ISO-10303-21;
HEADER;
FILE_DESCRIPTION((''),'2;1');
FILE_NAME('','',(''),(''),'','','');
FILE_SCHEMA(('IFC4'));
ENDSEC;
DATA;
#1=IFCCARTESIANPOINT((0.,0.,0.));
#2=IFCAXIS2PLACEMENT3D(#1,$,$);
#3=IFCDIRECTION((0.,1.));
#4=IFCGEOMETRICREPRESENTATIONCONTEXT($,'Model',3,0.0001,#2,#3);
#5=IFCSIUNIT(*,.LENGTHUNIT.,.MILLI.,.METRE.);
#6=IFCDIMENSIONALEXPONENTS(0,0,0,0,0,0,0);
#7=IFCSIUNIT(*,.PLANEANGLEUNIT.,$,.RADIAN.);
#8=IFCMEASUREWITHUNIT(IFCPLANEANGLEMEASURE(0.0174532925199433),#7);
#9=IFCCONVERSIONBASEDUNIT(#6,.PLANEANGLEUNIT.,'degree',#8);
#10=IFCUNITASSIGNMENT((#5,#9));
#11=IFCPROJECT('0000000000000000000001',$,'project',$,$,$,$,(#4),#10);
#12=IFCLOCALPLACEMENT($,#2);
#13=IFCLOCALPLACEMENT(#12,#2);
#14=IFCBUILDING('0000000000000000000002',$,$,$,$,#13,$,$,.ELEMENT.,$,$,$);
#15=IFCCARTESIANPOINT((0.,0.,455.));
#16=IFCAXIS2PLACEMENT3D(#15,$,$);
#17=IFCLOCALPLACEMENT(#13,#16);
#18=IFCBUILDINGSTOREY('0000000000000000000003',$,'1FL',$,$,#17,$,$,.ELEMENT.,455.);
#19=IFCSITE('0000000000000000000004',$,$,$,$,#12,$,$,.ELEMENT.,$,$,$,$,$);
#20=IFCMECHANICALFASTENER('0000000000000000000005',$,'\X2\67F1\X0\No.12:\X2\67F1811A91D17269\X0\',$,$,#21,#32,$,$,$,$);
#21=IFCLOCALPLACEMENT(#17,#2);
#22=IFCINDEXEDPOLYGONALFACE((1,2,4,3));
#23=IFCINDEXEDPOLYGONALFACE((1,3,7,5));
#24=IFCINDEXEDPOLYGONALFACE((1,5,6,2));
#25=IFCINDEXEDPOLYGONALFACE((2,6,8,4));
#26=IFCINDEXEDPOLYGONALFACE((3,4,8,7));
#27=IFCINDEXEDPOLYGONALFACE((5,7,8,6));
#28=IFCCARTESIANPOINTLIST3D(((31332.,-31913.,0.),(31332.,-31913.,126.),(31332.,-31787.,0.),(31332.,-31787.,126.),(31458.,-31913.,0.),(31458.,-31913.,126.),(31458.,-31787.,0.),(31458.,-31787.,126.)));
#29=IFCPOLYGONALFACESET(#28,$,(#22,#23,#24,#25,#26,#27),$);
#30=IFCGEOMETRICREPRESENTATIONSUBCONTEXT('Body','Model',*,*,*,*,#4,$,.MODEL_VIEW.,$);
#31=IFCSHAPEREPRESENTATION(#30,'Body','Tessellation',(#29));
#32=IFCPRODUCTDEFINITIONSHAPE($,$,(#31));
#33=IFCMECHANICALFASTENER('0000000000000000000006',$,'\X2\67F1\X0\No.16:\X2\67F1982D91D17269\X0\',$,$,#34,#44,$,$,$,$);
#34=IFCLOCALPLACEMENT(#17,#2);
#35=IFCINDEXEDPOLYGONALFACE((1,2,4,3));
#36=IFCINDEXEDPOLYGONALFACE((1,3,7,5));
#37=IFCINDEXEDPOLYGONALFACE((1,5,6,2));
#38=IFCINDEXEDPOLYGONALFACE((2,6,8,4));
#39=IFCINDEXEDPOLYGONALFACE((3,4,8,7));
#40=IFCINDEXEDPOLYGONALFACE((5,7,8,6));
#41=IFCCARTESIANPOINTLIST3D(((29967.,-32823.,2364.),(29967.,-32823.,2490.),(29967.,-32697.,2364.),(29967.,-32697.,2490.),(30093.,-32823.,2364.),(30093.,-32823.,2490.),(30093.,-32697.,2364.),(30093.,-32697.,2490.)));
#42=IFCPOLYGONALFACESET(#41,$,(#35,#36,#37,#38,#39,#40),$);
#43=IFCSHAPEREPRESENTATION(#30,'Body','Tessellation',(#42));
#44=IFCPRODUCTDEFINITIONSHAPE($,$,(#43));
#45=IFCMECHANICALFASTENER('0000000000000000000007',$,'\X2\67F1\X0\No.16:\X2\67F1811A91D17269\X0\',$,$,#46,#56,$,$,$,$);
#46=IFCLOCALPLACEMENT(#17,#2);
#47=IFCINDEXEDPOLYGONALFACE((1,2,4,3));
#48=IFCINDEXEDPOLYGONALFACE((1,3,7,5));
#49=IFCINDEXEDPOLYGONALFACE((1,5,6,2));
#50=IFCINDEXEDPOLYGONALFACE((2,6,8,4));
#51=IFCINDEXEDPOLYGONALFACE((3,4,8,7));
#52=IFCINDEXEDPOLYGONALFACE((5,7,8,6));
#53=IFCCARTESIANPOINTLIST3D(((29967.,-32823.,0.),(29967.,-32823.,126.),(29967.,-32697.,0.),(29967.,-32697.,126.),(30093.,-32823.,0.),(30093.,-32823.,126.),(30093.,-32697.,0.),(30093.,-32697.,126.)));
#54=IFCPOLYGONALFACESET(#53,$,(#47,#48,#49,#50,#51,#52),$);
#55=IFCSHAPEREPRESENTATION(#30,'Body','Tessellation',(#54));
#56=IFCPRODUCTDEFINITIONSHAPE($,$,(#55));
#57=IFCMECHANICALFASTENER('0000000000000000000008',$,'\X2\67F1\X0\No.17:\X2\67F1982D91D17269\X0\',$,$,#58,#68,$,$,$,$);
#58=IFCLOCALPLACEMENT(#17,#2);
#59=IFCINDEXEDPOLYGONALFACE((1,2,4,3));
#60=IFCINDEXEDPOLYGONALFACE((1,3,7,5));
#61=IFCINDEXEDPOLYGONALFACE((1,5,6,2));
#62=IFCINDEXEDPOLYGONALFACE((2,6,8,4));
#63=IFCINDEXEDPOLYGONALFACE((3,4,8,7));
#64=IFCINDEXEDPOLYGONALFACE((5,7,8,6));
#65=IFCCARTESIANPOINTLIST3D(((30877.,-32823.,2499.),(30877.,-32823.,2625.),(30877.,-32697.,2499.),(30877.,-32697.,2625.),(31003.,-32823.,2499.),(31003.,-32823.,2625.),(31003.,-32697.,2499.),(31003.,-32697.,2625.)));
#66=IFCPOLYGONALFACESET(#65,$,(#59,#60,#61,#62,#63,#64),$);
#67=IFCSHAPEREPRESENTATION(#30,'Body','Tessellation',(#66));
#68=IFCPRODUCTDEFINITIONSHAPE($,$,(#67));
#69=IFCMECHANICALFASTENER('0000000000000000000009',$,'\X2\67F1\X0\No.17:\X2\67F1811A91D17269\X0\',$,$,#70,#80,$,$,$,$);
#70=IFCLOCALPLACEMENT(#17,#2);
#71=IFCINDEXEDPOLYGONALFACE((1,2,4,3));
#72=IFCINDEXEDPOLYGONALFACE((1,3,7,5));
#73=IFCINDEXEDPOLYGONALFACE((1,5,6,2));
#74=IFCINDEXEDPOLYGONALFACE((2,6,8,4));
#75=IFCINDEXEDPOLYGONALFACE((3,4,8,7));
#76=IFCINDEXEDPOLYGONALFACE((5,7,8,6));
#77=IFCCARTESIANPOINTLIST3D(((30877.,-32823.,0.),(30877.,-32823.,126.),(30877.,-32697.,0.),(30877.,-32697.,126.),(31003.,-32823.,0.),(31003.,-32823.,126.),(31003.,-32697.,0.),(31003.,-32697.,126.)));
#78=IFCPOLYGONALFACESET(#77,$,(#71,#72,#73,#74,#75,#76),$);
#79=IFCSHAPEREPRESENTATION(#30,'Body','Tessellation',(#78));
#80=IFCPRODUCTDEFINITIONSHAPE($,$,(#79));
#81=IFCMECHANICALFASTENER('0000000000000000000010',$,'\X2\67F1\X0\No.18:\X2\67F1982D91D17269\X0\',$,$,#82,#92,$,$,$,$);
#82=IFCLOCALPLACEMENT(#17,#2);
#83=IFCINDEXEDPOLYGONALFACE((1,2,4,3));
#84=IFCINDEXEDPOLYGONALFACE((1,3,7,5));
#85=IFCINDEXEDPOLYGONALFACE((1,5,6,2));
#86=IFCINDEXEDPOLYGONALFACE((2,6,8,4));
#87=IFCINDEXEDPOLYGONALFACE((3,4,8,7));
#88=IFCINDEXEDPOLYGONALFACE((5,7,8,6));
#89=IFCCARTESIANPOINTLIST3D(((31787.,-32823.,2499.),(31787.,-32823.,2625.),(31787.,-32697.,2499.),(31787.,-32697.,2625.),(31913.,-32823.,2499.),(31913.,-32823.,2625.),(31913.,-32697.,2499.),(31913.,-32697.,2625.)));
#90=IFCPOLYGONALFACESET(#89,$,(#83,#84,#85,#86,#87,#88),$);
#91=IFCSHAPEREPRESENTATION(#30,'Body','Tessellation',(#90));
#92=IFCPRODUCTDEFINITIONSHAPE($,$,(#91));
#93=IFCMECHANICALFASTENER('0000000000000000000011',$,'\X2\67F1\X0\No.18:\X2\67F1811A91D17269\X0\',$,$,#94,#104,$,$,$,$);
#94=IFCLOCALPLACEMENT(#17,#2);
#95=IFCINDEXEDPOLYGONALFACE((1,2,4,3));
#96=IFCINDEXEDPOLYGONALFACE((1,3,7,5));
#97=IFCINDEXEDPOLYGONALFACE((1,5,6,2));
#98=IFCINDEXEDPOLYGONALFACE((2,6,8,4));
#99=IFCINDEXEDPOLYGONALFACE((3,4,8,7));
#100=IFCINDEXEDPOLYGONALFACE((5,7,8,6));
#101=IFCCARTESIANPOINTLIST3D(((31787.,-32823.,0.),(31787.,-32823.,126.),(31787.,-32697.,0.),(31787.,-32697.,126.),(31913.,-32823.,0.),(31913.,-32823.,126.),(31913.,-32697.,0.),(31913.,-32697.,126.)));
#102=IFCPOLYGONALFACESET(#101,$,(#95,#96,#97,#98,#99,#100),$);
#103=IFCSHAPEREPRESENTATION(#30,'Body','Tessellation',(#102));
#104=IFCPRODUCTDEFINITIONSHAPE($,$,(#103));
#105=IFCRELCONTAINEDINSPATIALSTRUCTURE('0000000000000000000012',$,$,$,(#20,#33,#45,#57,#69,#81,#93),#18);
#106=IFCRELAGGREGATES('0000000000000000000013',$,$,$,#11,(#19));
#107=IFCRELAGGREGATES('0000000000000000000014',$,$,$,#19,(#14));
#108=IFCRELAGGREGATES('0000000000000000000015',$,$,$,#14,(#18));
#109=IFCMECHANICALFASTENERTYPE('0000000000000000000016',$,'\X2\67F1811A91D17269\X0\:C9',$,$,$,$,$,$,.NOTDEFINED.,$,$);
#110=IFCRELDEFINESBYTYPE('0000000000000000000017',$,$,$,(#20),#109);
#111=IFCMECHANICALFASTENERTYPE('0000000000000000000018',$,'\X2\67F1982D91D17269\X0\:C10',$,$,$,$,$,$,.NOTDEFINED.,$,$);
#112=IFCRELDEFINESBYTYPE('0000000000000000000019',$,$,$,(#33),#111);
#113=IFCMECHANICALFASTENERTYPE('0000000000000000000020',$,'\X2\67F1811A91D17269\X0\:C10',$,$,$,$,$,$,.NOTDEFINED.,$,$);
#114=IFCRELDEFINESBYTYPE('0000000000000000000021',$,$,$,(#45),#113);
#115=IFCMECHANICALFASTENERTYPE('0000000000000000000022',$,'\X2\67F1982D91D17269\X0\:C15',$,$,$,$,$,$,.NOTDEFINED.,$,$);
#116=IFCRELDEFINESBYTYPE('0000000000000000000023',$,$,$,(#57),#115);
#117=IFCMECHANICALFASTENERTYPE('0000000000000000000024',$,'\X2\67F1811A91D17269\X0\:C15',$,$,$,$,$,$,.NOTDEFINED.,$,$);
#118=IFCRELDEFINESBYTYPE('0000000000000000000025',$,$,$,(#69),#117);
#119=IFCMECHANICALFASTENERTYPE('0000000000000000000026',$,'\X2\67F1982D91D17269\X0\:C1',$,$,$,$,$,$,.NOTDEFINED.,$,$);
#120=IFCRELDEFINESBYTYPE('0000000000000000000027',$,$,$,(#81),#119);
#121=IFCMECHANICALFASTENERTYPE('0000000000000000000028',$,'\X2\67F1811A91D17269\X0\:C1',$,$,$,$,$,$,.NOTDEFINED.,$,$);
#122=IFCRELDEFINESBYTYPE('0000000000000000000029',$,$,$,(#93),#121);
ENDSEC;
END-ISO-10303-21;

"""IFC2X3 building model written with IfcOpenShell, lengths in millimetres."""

from ifc_helpers import new_model, entity, si_unit, converted_unit, direction, frame, origin, origin_with_axes, origin_2d, place, context, subcontext, project, spatial, rectangle, extrude, type_object, element, save


model = new_model("IFC2X3")

# Units and contexts
model_context = context("Model", 3, precision=0.0001, world=origin(), true_north=direction((0.0, 1.0)))
body_context = subcontext(model_context, "Body", "Model", "MODEL_VIEW")
ifc_project = project(units=[si_unit("LENGTHUNIT", "METRE", prefix="MILLI"), converted_unit("PLANEANGLEUNIT", "degree", entity("IfcPlaneAngleMeasure", 0.0174532925199433), si_unit("PLANEANGLEUNIT", "RADIAN"), dimensions=[0, 0, 0, 0, 0, 0, 0])], contexts=[model_context])

# Site, building, storey
site_placement = place(None, origin())
site = spatial("IfcSite", under=ifc_project, at=site_placement, CompositionType="ELEMENT")
building_placement = place(site_placement, origin())
building = spatial("IfcBuilding", under=site, at=building_placement, CompositionType="ELEMENT")
storey_placement = place(building_placement, frame((0.0, 0.0, 455.0)))
storey = spatial("IfcBuildingStorey", under=building, at=storey_placement, Name="1FL", CompositionType="ELEMENT", Elevation=455.0)

# Mechanical fasteners
mechanical_fastener_type_1 = type_object("IfcMechanicalFastenerType", Name="柱脚金物:C9")
mechanical_fastener_1_placement = place(storey_placement, frame((31395.0, -31850.0, 0.0)))
element("IfcMechanicalFastener", 1, at=mechanical_fastener_1_placement, inside=storey, type_object=mechanical_fastener_type_1, Name="柱No.12:柱脚金物", context=body_context, shape_type="SweptSolid", body=[
    extrude(rectangle(XDim=126.0, YDim=126.0, at=origin_2d()), origin_with_axes(), (0.0, 0.0, 1.0), 126.0),
])
mechanical_fastener_type_2 = type_object("IfcMechanicalFastenerType", Name="柱頭金物:C10")
mechanical_fastener_2_placement = place(storey_placement, frame((30030.0, -32760.0, 2364.0)))
element("IfcMechanicalFastener", 2, at=mechanical_fastener_2_placement, inside=storey, type_object=mechanical_fastener_type_2, Name="柱No.16:柱頭金物", context=body_context, shape_type="SweptSolid", body=[
    extrude(rectangle(XDim=126.0, YDim=126.0, at=origin_2d()), origin_with_axes(), (0.0, 0.0, 1.0), 126.0),
])
mechanical_fastener_type_3 = type_object("IfcMechanicalFastenerType", Name="柱脚金物:C10")
mechanical_fastener_3_placement = place(storey_placement, frame((30030.0, -32760.0, 0.0)))
element("IfcMechanicalFastener", 3, at=mechanical_fastener_3_placement, inside=storey, type_object=mechanical_fastener_type_3, Name="柱No.16:柱脚金物", context=body_context, shape_type="SweptSolid", body=[
    extrude(rectangle(XDim=126.0, YDim=126.0, at=origin_2d()), origin_with_axes(), (0.0, 0.0, 1.0), 126.0),
])
mechanical_fastener_type_4 = type_object("IfcMechanicalFastenerType", Name="柱頭金物:C15")
mechanical_fastener_4_placement = place(storey_placement, frame((30940.0, -32760.0, 2499.0)))
element("IfcMechanicalFastener", 4, at=mechanical_fastener_4_placement, inside=storey, type_object=mechanical_fastener_type_4, Name="柱No.17:柱頭金物", context=body_context, shape_type="SweptSolid", body=[
    extrude(rectangle(XDim=126.0, YDim=126.0, at=origin_2d()), origin_with_axes(), (0.0, 0.0, 1.0), 126.0),
])
mechanical_fastener_type_5 = type_object("IfcMechanicalFastenerType", Name="柱脚金物:C15")
mechanical_fastener_5_placement = place(storey_placement, frame((30940.0, -32760.0, 0.0)))
element("IfcMechanicalFastener", 5, at=mechanical_fastener_5_placement, inside=storey, type_object=mechanical_fastener_type_5, Name="柱No.17:柱脚金物", context=body_context, shape_type="SweptSolid", body=[
    extrude(rectangle(XDim=126.0, YDim=126.0, at=origin_2d()), origin_with_axes(), (0.0, 0.0, 1.0), 126.0),
])
mechanical_fastener_type_6 = type_object("IfcMechanicalFastenerType", Name="柱頭金物:C1")
mechanical_fastener_6_placement = place(storey_placement, frame((31850.0, -32760.0, 2499.0)))
element("IfcMechanicalFastener", 6, at=mechanical_fastener_6_placement, inside=storey, type_object=mechanical_fastener_type_6, Name="柱No.18:柱頭金物", context=body_context, shape_type="SweptSolid", body=[
    extrude(rectangle(XDim=126.0, YDim=126.0, at=origin_2d()), origin_with_axes(), (0.0, 0.0, 1.0), 126.0),
])
mechanical_fastener_type_7 = type_object("IfcMechanicalFastenerType", Name="柱脚金物:C1")
mechanical_fastener_7_placement = place(storey_placement, frame((31850.0, -32760.0, 0.0)))
element("IfcMechanicalFastener", 7, at=mechanical_fastener_7_placement, inside=storey, type_object=mechanical_fastener_type_7, Name="柱No.18:柱脚金物", context=body_context, shape_type="SweptSolid", body=[
    extrude(rectangle(XDim=126.0, YDim=126.0, at=origin_2d()), origin_with_axes(), (0.0, 0.0, 1.0), 126.0),
])

save(model, "model.ifc")
